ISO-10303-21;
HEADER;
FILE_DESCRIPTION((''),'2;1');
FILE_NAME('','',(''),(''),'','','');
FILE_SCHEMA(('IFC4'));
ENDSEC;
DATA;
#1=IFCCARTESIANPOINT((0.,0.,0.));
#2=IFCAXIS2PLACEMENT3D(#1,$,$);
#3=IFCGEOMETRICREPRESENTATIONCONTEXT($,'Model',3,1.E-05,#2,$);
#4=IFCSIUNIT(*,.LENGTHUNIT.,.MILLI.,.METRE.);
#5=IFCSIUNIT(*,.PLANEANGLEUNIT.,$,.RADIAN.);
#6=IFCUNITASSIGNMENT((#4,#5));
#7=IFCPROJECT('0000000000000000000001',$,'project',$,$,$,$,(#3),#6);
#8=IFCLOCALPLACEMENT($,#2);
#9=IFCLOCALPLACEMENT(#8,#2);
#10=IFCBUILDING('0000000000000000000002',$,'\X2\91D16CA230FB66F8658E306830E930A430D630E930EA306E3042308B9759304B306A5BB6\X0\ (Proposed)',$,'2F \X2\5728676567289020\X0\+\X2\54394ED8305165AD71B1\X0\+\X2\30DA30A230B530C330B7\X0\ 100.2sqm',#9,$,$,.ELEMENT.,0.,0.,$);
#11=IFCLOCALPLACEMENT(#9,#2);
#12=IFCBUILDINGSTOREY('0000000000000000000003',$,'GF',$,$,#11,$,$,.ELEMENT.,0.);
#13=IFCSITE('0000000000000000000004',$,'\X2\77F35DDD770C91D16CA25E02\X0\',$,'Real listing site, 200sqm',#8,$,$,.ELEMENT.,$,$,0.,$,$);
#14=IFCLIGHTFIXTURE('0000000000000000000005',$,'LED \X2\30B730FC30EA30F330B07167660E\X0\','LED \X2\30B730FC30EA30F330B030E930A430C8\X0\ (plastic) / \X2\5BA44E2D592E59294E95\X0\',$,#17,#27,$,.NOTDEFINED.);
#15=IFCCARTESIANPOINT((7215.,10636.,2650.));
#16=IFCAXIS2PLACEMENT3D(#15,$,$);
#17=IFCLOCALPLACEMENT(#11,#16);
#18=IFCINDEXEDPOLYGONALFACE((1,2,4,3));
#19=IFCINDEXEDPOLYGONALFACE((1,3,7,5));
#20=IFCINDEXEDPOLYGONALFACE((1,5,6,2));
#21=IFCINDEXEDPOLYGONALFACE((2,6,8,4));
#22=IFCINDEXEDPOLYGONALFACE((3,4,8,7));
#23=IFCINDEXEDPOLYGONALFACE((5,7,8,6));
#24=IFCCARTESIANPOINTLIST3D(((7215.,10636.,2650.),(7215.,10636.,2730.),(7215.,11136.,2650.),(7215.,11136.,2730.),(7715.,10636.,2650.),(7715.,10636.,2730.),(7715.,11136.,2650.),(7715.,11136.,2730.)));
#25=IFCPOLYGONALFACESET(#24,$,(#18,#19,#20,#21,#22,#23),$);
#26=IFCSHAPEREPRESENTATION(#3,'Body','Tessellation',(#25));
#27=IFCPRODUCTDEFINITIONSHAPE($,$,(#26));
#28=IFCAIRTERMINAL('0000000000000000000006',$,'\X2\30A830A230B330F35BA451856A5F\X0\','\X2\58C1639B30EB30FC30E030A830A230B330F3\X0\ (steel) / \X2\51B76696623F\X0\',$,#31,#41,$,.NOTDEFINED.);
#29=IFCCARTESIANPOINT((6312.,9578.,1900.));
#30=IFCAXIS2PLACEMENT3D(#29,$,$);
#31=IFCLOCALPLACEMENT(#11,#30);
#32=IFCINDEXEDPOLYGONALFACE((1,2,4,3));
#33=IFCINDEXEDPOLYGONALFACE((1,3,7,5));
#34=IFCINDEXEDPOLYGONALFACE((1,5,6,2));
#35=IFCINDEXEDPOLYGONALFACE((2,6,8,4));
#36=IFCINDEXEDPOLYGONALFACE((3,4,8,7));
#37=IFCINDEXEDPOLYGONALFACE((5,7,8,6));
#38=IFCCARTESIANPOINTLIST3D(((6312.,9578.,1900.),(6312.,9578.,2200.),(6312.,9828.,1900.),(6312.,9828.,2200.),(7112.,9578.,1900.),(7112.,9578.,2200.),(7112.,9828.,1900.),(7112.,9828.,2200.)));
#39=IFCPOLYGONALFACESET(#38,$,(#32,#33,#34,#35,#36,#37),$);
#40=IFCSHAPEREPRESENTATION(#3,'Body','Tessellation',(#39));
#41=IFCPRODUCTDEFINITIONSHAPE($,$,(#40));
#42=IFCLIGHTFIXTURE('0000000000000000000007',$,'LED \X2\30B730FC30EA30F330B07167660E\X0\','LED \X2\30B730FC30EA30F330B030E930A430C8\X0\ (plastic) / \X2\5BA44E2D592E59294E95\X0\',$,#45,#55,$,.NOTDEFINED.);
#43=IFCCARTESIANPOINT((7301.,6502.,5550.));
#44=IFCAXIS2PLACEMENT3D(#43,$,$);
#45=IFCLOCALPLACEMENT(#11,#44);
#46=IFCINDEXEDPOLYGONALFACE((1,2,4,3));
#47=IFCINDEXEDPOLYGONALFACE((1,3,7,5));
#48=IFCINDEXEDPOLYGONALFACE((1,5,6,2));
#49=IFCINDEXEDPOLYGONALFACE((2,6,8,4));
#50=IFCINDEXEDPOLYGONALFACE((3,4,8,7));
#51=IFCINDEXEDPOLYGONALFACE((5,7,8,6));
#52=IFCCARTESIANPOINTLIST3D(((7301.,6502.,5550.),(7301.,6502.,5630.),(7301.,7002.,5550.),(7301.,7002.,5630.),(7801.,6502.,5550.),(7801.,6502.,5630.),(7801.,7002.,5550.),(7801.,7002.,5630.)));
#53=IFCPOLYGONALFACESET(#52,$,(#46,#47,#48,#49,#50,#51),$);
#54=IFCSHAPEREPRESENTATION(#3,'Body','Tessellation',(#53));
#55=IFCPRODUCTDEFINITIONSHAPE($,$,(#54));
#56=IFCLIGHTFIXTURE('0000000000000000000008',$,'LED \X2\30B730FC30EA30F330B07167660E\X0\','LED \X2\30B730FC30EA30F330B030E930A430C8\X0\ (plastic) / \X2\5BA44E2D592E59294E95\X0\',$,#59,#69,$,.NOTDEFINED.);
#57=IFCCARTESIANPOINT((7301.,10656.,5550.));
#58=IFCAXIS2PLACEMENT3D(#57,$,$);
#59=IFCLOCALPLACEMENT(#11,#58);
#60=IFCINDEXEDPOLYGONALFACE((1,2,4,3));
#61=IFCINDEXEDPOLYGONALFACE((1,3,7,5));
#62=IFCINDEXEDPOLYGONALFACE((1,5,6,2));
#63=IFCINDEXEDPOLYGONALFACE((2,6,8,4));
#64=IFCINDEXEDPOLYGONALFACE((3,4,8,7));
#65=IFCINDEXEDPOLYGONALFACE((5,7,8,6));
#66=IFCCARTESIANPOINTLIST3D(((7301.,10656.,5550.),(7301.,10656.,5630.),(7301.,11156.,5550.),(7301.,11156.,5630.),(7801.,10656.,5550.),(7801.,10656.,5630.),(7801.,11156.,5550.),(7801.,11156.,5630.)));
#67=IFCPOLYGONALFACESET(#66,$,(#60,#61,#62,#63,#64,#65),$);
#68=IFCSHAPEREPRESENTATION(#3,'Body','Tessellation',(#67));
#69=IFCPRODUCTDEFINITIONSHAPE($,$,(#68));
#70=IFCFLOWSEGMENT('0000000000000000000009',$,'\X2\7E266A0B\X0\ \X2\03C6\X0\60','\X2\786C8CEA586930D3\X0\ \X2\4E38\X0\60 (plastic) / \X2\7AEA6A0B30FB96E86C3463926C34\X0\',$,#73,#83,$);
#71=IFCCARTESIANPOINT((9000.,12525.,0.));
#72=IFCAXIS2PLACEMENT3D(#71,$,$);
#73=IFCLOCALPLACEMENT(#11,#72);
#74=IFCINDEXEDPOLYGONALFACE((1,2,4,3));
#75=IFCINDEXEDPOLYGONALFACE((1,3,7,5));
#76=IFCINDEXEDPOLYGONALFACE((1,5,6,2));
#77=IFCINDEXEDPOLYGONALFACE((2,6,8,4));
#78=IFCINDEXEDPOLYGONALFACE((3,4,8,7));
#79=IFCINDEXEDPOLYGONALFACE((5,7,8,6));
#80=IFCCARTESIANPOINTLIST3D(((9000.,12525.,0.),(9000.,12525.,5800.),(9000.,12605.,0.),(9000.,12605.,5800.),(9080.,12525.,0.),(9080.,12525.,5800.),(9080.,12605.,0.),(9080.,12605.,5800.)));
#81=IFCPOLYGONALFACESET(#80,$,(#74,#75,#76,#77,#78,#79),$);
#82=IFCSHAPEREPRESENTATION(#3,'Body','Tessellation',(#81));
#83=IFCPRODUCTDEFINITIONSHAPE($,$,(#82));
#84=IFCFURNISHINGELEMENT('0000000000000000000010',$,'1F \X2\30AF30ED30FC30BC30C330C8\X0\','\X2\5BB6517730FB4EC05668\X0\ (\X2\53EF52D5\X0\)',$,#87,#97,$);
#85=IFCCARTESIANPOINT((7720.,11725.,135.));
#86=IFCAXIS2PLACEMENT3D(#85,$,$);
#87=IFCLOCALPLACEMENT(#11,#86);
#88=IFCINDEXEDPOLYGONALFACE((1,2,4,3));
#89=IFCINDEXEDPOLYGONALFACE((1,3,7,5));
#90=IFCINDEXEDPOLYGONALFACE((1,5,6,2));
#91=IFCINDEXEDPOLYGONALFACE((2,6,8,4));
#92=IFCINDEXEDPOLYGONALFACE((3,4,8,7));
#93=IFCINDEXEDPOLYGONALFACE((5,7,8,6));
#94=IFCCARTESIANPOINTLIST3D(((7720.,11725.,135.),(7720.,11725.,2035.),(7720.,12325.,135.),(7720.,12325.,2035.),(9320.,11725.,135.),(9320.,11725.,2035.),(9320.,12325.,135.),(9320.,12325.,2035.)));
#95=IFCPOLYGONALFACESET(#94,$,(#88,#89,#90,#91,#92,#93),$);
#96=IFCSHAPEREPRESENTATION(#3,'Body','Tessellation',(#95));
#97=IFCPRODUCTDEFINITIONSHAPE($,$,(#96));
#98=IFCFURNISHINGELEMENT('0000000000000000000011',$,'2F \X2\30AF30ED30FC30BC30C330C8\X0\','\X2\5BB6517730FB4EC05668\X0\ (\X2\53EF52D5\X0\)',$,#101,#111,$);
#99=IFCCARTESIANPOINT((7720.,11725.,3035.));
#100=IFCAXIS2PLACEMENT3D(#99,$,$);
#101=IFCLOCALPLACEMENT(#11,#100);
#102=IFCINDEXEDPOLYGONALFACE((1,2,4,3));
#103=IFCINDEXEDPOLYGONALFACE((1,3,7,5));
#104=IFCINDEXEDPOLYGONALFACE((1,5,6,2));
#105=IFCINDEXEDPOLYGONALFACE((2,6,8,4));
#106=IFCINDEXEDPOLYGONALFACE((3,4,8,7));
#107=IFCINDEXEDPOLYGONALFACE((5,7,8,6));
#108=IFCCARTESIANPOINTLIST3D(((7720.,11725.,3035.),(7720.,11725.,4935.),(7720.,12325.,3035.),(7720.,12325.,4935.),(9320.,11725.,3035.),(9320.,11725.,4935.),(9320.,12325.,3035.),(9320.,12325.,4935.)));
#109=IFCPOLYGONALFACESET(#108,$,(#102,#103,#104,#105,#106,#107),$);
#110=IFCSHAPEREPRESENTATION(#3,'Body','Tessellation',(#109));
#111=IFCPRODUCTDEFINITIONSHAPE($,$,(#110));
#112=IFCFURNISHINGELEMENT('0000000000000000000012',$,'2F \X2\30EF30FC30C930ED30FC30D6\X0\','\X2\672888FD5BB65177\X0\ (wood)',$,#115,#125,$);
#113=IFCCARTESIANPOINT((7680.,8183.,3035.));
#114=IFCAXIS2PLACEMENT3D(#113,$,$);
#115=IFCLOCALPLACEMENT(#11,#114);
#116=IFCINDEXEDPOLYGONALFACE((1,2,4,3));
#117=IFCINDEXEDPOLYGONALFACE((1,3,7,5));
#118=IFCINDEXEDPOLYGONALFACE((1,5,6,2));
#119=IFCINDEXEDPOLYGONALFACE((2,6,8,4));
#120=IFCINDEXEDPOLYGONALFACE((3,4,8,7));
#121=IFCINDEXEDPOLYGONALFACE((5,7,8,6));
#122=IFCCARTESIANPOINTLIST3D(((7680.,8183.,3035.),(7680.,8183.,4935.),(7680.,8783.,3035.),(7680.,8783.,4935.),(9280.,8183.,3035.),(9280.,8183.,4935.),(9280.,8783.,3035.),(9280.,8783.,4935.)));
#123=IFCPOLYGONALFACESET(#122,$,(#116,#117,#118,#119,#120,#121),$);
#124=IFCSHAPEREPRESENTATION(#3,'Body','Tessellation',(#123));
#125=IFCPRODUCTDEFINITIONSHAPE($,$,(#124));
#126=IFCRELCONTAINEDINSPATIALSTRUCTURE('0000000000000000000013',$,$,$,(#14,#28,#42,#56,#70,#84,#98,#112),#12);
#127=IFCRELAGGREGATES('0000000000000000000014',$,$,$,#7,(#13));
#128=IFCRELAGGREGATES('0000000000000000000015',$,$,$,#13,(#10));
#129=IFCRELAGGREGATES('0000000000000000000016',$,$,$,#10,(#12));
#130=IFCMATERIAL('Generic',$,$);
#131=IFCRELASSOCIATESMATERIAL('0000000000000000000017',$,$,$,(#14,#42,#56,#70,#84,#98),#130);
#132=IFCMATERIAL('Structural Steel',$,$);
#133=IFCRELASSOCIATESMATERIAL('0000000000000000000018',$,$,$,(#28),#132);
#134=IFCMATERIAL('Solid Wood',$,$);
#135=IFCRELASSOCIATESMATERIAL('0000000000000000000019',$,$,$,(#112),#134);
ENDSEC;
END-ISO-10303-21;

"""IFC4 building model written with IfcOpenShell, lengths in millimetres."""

from ifc_helpers import new_model, si_unit, frame, frame_2d, origin, place, context, project, spatial, rectangle, extrude, material, element, save


model = new_model("IFC4")

# Units and contexts
model_context = context("Model", 3, precision=1e-05, world=origin())
ifc_project = project(units=[si_unit("LENGTHUNIT", "METRE", prefix="MILLI"), si_unit("PLANEANGLEUNIT", "RADIAN")], contexts=[model_context])

# Site, building, storey
site_placement = place(None, origin())
site = spatial("IfcSite", under=ifc_project, at=site_placement, Name="石川県金沢市", ObjectType="Real listing site, 200sqm", CompositionType="ELEMENT", RefElevation=0.0)
building_placement = place(site_placement, origin())
building = spatial("IfcBuilding", under=site, at=building_placement, Name="金沢・書斎とライブラリのある静かな家 (Proposed)", ObjectType="2F 在来木造+吹付け断熱+ペアサッシ 100.2sqm", CompositionType="ELEMENT", ElevationOfRefHeight=0.0, ElevationOfTerrain=0.0)
storey_placement = place(building_placement, origin())
storey = spatial("IfcBuildingStorey", under=building, at=storey_placement, Name="GF", CompositionType="ELEMENT", Elevation=0.0)

# Shared definitions
ifc_material_1 = material(Name="Solid Wood")

# Shared definitions
ifc_material_2 = material(Name="Structural Steel")

# Shared definitions
ifc_material_3 = material(Name="Generic")

# Light fixture
light_fixture_1_placement = place(storey_placement, frame((7215.0, 10636.0, 2650.0)))
element("IfcLightFixture", 1, at=light_fixture_1_placement, inside=storey, material=ifc_material_3, Name="LED シーリング照明", Description="LED シーリングライト (plastic) / 室中央天井", PredefinedType="NOTDEFINED", context=model_context, shape_type="SweptSolid", body=[
    extrude(rectangle(XDim=500.0, YDim=500.0, at=frame_2d((250.0, 250.0))), frame((7215.0, 10636.0, 2650.0)), (0.0, 0.0, 1.0), 80.0),
])

# Air terminal
air_terminal_placement = place(storey_placement, frame((6312.0, 9578.0, 1900.0)))
element("IfcAirTerminal", 2, at=air_terminal_placement, inside=storey, material=ifc_material_2, Name="エアコン室内機", Description="壁掛ルームエアコン (steel) / 冷暖房", PredefinedType="NOTDEFINED", context=model_context, shape_type="SweptSolid", body=[
    extrude(rectangle(XDim=800.0, YDim=250.0, at=frame_2d((400.0, 125.0))), frame((6312.0, 9578.0, 1900.0)), (0.0, 0.0, 1.0), 300.0),
])

# Light fixtures
light_fixture_2_placement = place(storey_placement, frame((7301.0, 6502.0, 5550.0)))
element("IfcLightFixture", 3, at=light_fixture_2_placement, inside=storey, material=ifc_material_3, Name="LED シーリング照明", Description="LED シーリングライト (plastic) / 室中央天井", PredefinedType="NOTDEFINED", context=model_context, shape_type="SweptSolid", body=[
    extrude(rectangle(XDim=500.0, YDim=500.0, at=frame_2d((250.0, 250.0))), frame((7301.0, 6502.0, 5550.0)), (0.0, 0.0, 1.0), 80.0),
])
light_fixture_3_placement = place(storey_placement, frame((7301.0, 10656.0, 5550.0)))
element("IfcLightFixture", 4, at=light_fixture_3_placement, inside=storey, material=ifc_material_3, Name="LED シーリング照明", Description="LED シーリングライト (plastic) / 室中央天井", PredefinedType="NOTDEFINED", context=model_context, shape_type="SweptSolid", body=[
    extrude(rectangle(XDim=500.0, YDim=500.0, at=frame_2d((250.0, 250.0))), frame((7301.0, 10656.0, 5550.0)), (0.0, 0.0, 1.0), 80.0),
])

# Flow segment
flow_segment_placement = place(storey_placement, frame((9000.0, 12525.0, 0.0)))
element("IfcFlowSegment", 5, at=flow_segment_placement, inside=storey, material=ifc_material_3, Name="縦樋 φ60", Description="硬質塩ビ 丸60 (plastic) / 竪樋・雨水排水", context=model_context, shape_type="SweptSolid", body=[
    extrude(rectangle(XDim=80.0, YDim=80.0, at=frame_2d((40.0, 40.0))), frame((9000.0, 12525.0, 0.0)), (0.0, 0.0, 1.0), 5800.0),
])

# Furnishing elements
furnishing_1_placement = place(storey_placement, frame((7720.0, 11725.0, 135.0)))
element("IfcFurnishingElement", 6, at=furnishing_1_placement, inside=storey, material=ifc_material_3, Name="1F クローゼット", Description="家具・什器 (可動)", context=model_context, shape_type="SweptSolid", body=[
    extrude(rectangle(XDim=1600.0, YDim=600.0, at=frame_2d((800.0, 300.0))), frame((7720.0, 11725.0, 135.0)), (0.0, 0.0, 1.0), 1900.0),
])
furnishing_2_placement = place(storey_placement, frame((7720.0, 11725.0, 3035.0)))
element("IfcFurnishingElement", 7, at=furnishing_2_placement, inside=storey, material=ifc_material_3, Name="2F クローゼット", Description="家具・什器 (可動)", context=model_context, shape_type="SweptSolid", body=[
    extrude(rectangle(XDim=1600.0, YDim=600.0, at=frame_2d((800.0, 300.0))), frame((7720.0, 11725.0, 3035.0)), (0.0, 0.0, 1.0), 1900.0),
])
furnishing_3_placement = place(storey_placement, frame((7680.0, 8183.0, 3035.0)))
element("IfcFurnishingElement", 8, at=furnishing_3_placement, inside=storey, material=ifc_material_1, Name="2F ワードローブ", Description="木製家具 (wood)", context=model_context, shape_type="SweptSolid", body=[
    extrude(rectangle(XDim=1600.0, YDim=600.0, at=frame_2d((800.0, 300.0))), frame((7680.0, 8183.0, 3035.0)), (0.0, 0.0, 1.0), 1900.0),
])

save(model, "model.ifc")
